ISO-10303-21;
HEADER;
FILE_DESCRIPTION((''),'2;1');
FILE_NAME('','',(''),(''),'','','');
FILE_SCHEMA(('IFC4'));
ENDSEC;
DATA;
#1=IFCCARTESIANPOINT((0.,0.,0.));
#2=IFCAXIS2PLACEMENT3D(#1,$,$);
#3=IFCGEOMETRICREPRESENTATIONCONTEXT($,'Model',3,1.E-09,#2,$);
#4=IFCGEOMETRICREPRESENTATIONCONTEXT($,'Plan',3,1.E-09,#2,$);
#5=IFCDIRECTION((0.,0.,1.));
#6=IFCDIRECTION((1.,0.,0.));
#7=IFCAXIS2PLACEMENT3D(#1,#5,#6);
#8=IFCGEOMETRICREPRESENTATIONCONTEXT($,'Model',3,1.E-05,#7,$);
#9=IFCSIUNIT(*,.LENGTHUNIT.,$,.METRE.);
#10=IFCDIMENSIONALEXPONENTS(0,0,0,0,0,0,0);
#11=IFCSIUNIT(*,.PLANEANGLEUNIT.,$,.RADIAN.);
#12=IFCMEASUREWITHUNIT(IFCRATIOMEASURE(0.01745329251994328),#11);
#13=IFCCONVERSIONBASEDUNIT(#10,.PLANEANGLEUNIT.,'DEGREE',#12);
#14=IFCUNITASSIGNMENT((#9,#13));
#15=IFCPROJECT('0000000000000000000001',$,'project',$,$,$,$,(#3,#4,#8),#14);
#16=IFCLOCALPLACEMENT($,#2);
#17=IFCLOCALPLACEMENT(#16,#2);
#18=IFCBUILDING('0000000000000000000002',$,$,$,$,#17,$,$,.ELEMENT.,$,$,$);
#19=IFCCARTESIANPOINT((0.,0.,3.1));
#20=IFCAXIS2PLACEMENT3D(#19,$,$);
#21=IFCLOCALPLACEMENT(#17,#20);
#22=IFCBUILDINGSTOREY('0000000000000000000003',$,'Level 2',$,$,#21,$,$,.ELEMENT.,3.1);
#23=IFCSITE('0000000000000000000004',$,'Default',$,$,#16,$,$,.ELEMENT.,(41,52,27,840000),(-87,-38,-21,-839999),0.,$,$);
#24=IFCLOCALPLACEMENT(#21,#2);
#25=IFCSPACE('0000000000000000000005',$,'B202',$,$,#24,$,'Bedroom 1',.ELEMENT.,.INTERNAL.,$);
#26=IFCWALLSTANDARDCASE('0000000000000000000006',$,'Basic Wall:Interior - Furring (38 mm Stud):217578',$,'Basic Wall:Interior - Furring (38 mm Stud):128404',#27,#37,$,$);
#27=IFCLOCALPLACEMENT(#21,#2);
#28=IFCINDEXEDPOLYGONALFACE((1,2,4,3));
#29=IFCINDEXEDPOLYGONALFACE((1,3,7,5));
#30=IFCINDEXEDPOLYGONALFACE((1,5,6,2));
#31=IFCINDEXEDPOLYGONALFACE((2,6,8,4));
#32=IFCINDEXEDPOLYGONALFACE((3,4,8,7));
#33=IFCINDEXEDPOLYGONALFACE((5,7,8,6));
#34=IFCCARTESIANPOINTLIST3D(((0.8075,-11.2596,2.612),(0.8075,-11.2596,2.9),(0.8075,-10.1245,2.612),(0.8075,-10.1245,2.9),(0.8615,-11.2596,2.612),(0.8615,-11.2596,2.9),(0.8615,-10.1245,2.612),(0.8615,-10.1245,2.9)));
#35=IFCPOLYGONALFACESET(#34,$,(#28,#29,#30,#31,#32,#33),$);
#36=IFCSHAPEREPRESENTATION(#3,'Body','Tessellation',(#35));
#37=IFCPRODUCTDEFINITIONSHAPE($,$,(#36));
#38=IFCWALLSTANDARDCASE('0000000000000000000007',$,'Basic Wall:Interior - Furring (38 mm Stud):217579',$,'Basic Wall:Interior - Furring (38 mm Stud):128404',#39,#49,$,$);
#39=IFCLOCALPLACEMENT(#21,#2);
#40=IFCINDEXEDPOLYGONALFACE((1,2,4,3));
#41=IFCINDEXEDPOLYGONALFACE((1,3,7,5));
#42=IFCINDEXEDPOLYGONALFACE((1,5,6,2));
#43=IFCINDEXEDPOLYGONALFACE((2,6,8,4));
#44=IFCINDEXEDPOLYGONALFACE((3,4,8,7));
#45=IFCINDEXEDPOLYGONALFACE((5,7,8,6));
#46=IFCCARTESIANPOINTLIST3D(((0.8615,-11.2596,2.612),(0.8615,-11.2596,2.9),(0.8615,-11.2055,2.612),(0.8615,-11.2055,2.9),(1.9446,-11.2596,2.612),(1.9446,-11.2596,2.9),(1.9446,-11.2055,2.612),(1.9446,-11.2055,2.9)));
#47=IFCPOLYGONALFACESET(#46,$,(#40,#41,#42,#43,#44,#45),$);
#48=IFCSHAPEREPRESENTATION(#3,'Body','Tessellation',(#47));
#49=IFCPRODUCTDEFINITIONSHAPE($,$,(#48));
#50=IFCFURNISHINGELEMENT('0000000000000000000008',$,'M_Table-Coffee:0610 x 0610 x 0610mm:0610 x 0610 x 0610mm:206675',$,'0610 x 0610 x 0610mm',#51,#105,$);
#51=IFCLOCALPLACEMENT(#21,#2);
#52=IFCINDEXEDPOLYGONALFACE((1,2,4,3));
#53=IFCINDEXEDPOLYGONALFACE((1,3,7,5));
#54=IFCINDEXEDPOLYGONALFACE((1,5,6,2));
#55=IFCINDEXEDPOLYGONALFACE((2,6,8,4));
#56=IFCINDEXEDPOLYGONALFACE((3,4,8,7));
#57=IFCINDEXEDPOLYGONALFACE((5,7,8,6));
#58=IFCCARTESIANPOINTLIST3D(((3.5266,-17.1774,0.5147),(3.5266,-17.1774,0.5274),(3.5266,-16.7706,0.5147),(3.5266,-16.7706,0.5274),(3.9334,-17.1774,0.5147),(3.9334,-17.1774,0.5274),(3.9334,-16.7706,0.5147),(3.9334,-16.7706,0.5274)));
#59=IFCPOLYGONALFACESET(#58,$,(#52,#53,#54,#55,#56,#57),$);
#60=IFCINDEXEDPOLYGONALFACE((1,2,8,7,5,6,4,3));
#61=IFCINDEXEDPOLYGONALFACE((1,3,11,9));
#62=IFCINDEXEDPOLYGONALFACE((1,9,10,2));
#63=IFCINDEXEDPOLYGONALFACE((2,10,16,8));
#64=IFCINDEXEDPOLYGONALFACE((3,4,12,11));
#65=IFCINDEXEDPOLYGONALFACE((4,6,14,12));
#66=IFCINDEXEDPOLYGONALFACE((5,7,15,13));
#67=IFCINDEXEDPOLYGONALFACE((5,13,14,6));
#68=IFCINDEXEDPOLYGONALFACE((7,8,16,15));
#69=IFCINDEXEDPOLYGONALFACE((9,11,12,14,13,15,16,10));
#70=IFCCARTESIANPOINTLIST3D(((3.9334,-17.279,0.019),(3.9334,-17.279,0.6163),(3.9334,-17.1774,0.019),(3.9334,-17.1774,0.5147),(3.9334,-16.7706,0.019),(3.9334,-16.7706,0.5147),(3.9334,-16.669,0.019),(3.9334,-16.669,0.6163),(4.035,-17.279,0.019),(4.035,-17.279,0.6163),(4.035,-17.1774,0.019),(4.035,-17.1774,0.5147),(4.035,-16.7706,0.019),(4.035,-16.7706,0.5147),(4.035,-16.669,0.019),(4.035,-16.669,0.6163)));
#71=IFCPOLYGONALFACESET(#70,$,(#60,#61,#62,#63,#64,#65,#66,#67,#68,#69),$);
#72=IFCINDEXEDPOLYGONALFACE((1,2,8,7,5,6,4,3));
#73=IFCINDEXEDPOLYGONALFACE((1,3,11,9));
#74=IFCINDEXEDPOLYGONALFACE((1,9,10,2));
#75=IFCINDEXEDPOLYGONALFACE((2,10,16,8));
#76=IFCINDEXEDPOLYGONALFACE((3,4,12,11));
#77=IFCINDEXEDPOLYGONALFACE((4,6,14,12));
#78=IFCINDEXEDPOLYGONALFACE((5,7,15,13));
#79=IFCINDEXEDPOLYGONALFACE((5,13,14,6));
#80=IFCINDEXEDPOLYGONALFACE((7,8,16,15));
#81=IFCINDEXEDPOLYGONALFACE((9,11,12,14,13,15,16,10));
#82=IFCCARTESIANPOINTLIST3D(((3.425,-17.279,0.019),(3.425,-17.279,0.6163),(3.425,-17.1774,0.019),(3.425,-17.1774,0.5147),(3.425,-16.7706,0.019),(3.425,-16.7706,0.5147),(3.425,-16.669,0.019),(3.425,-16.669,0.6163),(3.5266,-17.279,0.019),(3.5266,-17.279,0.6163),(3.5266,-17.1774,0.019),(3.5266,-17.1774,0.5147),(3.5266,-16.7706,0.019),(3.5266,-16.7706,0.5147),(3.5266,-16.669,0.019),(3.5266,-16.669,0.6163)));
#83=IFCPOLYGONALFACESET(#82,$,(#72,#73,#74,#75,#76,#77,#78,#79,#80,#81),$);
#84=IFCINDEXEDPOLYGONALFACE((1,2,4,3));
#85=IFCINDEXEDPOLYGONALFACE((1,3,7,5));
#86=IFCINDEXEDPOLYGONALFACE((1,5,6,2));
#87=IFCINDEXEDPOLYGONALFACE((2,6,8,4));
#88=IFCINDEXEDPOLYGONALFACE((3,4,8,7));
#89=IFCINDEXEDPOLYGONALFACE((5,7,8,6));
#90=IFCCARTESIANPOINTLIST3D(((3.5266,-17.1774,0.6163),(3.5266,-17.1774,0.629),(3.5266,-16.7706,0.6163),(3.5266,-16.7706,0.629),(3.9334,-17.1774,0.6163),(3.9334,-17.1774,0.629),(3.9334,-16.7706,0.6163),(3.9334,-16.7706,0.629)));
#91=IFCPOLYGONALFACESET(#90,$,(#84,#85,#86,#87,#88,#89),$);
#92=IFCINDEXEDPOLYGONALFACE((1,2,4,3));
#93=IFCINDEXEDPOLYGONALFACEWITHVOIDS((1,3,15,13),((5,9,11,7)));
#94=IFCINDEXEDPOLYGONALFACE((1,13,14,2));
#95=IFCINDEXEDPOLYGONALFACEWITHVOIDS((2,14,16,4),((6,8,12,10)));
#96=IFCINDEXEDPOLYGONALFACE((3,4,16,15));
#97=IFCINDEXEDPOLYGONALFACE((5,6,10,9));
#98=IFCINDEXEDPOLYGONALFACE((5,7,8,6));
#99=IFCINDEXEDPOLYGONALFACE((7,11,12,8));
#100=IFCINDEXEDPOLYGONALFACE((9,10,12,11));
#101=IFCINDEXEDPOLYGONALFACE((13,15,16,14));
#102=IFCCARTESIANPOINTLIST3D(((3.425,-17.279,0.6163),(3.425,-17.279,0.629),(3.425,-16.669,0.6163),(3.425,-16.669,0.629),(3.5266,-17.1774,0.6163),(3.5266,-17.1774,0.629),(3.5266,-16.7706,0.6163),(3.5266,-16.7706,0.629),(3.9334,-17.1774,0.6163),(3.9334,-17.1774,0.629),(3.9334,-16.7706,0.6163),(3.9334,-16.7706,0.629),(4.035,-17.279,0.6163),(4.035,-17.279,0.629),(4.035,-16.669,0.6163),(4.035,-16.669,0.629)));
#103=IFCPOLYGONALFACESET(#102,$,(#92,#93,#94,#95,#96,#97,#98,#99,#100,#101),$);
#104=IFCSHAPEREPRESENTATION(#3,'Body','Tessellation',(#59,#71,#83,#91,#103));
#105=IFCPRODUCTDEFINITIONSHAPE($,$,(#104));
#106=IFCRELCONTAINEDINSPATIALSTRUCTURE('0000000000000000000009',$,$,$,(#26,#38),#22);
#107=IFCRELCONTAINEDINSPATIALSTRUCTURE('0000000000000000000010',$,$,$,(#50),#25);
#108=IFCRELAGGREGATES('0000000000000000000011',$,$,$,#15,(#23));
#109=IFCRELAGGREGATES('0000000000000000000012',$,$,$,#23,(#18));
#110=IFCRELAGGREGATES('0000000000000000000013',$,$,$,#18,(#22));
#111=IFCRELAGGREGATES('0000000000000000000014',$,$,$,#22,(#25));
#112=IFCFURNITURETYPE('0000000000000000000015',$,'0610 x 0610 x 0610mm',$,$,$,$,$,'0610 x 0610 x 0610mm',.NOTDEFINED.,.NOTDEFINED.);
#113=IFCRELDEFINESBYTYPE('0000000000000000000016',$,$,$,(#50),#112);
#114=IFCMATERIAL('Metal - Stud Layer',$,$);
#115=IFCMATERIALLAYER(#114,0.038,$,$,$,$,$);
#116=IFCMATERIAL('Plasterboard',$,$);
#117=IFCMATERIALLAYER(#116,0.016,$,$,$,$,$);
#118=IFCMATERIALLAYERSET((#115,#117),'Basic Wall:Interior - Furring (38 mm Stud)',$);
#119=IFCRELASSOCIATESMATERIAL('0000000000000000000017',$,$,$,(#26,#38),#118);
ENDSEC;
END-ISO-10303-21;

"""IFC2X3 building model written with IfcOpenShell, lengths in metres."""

from ifc_helpers import new_model, entity, si_unit, converted_unit, frame, frame_2d, origin, origin_with_axes, origin_2d_with_axis, place, context, project, spatial, polyline, rectangle, outline, extrude, source, transform, mapped, material, layer, layer_set, layer_usage, type_object, type_shapes, element, save


model = new_model("IFC2X3")

# Units and contexts
model_context_1 = context("Model", 3, precision=1e-09, world=origin())
plan_context = context("Plan", 3, precision=1e-09, world=origin())
model_context_2 = context("Model", 3, precision=1e-05, world=origin_with_axes())
ifc_project = project(units=[si_unit("LENGTHUNIT", "METRE"), converted_unit("PLANEANGLEUNIT", "DEGREE", entity("IfcRatioMeasure", 0.01745329251994328), si_unit("PLANEANGLEUNIT", "RADIAN"), dimensions=[0, 0, 0, 0, 0, 0, 0])], contexts=[model_context_1, plan_context, model_context_2])

# Site, building, storey
site_placement = place(None, origin())
site = spatial("IfcSite", under=ifc_project, at=site_placement, Name="Default", CompositionType="ELEMENT", RefLatitude=(41, 52, 27, 840000), RefLongitude=(-87, -38, -21, -839999), RefElevation=0.0)
building_placement = place(site_placement, origin())
building = spatial("IfcBuilding", under=site, at=building_placement, CompositionType="ELEMENT")
storey_placement = place(building_placement, frame((0.0, 0.0, 3.1)))
storey = spatial("IfcBuildingStorey", under=building, at=storey_placement, Name="Level 2", CompositionType="ELEMENT", Elevation=3.1)

# Shared definitions
ifc_material_1 = material(Name="Metal - Stud Layer")
ifc_material_2 = material(Name="Plasterboard")

# Walls
ifc_layer_1 = layer(ifc_material_1, 0.038)
ifc_layer_2 = layer(ifc_material_2, 0.016)
ifc_layer_set_1 = layer_set([ifc_layer_1, ifc_layer_2], Name="Basic Wall:Interior - Furring (38 mm Stud)")
ifc_layer_usage_1 = layer_usage(ifc_layer_set_1, "AXIS2", "NEGATIVE", 0.027)
wall_1_placement = place(storey_placement, frame((0.8345, -11.2596, 2.612), z_axis=(0.0, 0.0, 1.0), x_axis=(0.0, 1.0, 0.0)))
element("IfcWallStandardCase", 1, at=wall_1_placement, inside=storey, material=ifc_layer_usage_1, Name="Basic Wall:Interior - Furring (38 mm Stud):217578", ObjectType="Basic Wall:Interior - Furring (38 mm Stud):128404", context=model_context_1, shape_type="SweptSolid", body=[
    extrude(rectangle(XDim=1.1351, YDim=0.054, at=frame_2d((0.5675, 0.0), x_axis=(-1.0, 0.0))), origin(), (0.0, 0.0, 1.0), 0.288),
])
ifc_layer_usage_2 = layer_usage(ifc_layer_set_1, "AXIS2", "NEGATIVE", 0.027)
wall_2_placement = place(storey_placement, frame((1.9446, -11.2325, 2.612), z_axis=(0.0, 0.0, 1.0), x_axis=(-1.0, 0.0, 0.0)))
element("IfcWallStandardCase", 2, at=wall_2_placement, inside=storey, material=ifc_layer_usage_2, Name="Basic Wall:Interior - Furring (38 mm Stud):217579", ObjectType="Basic Wall:Interior - Furring (38 mm Stud):128404", context=model_context_1, shape_type="SweptSolid", body=[
    extrude(rectangle(XDim=1.0831, YDim=0.054, at=frame_2d((0.5415, 0.0), x_axis=(-1.0, 0.0))), origin(), (0.0, 0.0, 1.0), 0.288),
])

# Shared definitions
space_placement = place(storey_placement, origin())
space = spatial("IfcSpace", under=storey, at=space_placement, Name="B202", LongName="Bedroom 1", CompositionType="ELEMENT", InteriorOrExteriorSpace="INTERNAL")

# Furnishing element
furniture_type = type_object("IfcFurnitureType", Name="0610 x 0610 x 0610mm", ElementType="0610 x 0610 x 0610mm", AssemblyPlace="NOTDEFINED")
shared_shape_1 = source(origin(), model_context_1, "Body", "SweptSolid", [
    extrude(rectangle(XDim=0.4068, YDim=0.4068, at=origin_2d_with_axis()), frame((0.0183, 0.0952, 0.4957), z_axis=(0.0, 0.0, 1.0), x_axis=(-1.0, 0.0, 0.0)), (0.0, 0.0, 1.0), 0.0127),
    extrude(outline(polyline([(-0.2732, -0.305), (0.324, -0.305), (0.324, 0.305), (-0.2732, 0.305), (-0.2732, 0.2034), (0.2225, 0.2034), (0.2225, -0.2034), (-0.2732, -0.2034), (-0.2732, -0.305)])), frame((0.2217, 0.0952, 0.2732), z_axis=(1.0, 0.0, 0.0), x_axis=(0.0, 0.0, 1.0)), (0.0, 0.0, 1.0), 0.1016),
    extrude(outline(polyline([(-0.305, -0.3241), (0.305, -0.3241), (0.305, 0.2733), (0.2034, 0.2733), (0.2034, -0.2224), (-0.2034, -0.2224), (-0.2034, 0.2733), (-0.305, 0.2733), (-0.305, -0.3241)])), frame((-0.2867, 0.0952, 0.2733), z_axis=(1.0, 0.0, 0.0), x_axis=(0.0, -1.0, 0.0)), (0.0, 0.0, 1.0), 0.1016),
    extrude(rectangle(XDim=0.4068, YDim=0.4068, at=origin_2d_with_axis()), frame((0.0183, 0.0952, 0.5973), z_axis=(0.0, 0.0, 1.0), x_axis=(-1.0, 0.0, 0.0)), (0.0, 0.0, 1.0), 0.0127),
    extrude(outline(polyline([(-0.305, -0.305), (0.305, -0.305), (0.305, 0.305), (-0.305, 0.305), (-0.305, -0.305)]), holes=[polyline([(-0.2034, -0.2034), (-0.2034, 0.2034), (0.2034, 0.2034), (0.2034, -0.2034), (-0.2034, -0.2034)])]), frame((0.0183, 0.0952, 0.5973), z_axis=(0.0, 0.0, 1.0), x_axis=(-1.0, 0.0, 0.0)), (0.0, 0.0, 1.0), 0.0127),
])
type_shapes(furniture_type, [shared_shape_1])
furnishing_placement = place(space_placement, frame((3.7117, -17.0692, 0.019)))
element("IfcFurnishingElement", 3, at=furnishing_placement, inside=space, type_object=furniture_type, Name="M_Table-Coffee:0610 x 0610 x 0610mm:0610 x 0610 x 0610mm:206675", ObjectType="0610 x 0610 x 0610mm", context=model_context_1, shape_type="MappedRepresentation", body=[
    mapped(shared_shape_1, transform((0.0, 0.0, 0.0), scale=1.0)),
])

save(model, "model.ifc")
